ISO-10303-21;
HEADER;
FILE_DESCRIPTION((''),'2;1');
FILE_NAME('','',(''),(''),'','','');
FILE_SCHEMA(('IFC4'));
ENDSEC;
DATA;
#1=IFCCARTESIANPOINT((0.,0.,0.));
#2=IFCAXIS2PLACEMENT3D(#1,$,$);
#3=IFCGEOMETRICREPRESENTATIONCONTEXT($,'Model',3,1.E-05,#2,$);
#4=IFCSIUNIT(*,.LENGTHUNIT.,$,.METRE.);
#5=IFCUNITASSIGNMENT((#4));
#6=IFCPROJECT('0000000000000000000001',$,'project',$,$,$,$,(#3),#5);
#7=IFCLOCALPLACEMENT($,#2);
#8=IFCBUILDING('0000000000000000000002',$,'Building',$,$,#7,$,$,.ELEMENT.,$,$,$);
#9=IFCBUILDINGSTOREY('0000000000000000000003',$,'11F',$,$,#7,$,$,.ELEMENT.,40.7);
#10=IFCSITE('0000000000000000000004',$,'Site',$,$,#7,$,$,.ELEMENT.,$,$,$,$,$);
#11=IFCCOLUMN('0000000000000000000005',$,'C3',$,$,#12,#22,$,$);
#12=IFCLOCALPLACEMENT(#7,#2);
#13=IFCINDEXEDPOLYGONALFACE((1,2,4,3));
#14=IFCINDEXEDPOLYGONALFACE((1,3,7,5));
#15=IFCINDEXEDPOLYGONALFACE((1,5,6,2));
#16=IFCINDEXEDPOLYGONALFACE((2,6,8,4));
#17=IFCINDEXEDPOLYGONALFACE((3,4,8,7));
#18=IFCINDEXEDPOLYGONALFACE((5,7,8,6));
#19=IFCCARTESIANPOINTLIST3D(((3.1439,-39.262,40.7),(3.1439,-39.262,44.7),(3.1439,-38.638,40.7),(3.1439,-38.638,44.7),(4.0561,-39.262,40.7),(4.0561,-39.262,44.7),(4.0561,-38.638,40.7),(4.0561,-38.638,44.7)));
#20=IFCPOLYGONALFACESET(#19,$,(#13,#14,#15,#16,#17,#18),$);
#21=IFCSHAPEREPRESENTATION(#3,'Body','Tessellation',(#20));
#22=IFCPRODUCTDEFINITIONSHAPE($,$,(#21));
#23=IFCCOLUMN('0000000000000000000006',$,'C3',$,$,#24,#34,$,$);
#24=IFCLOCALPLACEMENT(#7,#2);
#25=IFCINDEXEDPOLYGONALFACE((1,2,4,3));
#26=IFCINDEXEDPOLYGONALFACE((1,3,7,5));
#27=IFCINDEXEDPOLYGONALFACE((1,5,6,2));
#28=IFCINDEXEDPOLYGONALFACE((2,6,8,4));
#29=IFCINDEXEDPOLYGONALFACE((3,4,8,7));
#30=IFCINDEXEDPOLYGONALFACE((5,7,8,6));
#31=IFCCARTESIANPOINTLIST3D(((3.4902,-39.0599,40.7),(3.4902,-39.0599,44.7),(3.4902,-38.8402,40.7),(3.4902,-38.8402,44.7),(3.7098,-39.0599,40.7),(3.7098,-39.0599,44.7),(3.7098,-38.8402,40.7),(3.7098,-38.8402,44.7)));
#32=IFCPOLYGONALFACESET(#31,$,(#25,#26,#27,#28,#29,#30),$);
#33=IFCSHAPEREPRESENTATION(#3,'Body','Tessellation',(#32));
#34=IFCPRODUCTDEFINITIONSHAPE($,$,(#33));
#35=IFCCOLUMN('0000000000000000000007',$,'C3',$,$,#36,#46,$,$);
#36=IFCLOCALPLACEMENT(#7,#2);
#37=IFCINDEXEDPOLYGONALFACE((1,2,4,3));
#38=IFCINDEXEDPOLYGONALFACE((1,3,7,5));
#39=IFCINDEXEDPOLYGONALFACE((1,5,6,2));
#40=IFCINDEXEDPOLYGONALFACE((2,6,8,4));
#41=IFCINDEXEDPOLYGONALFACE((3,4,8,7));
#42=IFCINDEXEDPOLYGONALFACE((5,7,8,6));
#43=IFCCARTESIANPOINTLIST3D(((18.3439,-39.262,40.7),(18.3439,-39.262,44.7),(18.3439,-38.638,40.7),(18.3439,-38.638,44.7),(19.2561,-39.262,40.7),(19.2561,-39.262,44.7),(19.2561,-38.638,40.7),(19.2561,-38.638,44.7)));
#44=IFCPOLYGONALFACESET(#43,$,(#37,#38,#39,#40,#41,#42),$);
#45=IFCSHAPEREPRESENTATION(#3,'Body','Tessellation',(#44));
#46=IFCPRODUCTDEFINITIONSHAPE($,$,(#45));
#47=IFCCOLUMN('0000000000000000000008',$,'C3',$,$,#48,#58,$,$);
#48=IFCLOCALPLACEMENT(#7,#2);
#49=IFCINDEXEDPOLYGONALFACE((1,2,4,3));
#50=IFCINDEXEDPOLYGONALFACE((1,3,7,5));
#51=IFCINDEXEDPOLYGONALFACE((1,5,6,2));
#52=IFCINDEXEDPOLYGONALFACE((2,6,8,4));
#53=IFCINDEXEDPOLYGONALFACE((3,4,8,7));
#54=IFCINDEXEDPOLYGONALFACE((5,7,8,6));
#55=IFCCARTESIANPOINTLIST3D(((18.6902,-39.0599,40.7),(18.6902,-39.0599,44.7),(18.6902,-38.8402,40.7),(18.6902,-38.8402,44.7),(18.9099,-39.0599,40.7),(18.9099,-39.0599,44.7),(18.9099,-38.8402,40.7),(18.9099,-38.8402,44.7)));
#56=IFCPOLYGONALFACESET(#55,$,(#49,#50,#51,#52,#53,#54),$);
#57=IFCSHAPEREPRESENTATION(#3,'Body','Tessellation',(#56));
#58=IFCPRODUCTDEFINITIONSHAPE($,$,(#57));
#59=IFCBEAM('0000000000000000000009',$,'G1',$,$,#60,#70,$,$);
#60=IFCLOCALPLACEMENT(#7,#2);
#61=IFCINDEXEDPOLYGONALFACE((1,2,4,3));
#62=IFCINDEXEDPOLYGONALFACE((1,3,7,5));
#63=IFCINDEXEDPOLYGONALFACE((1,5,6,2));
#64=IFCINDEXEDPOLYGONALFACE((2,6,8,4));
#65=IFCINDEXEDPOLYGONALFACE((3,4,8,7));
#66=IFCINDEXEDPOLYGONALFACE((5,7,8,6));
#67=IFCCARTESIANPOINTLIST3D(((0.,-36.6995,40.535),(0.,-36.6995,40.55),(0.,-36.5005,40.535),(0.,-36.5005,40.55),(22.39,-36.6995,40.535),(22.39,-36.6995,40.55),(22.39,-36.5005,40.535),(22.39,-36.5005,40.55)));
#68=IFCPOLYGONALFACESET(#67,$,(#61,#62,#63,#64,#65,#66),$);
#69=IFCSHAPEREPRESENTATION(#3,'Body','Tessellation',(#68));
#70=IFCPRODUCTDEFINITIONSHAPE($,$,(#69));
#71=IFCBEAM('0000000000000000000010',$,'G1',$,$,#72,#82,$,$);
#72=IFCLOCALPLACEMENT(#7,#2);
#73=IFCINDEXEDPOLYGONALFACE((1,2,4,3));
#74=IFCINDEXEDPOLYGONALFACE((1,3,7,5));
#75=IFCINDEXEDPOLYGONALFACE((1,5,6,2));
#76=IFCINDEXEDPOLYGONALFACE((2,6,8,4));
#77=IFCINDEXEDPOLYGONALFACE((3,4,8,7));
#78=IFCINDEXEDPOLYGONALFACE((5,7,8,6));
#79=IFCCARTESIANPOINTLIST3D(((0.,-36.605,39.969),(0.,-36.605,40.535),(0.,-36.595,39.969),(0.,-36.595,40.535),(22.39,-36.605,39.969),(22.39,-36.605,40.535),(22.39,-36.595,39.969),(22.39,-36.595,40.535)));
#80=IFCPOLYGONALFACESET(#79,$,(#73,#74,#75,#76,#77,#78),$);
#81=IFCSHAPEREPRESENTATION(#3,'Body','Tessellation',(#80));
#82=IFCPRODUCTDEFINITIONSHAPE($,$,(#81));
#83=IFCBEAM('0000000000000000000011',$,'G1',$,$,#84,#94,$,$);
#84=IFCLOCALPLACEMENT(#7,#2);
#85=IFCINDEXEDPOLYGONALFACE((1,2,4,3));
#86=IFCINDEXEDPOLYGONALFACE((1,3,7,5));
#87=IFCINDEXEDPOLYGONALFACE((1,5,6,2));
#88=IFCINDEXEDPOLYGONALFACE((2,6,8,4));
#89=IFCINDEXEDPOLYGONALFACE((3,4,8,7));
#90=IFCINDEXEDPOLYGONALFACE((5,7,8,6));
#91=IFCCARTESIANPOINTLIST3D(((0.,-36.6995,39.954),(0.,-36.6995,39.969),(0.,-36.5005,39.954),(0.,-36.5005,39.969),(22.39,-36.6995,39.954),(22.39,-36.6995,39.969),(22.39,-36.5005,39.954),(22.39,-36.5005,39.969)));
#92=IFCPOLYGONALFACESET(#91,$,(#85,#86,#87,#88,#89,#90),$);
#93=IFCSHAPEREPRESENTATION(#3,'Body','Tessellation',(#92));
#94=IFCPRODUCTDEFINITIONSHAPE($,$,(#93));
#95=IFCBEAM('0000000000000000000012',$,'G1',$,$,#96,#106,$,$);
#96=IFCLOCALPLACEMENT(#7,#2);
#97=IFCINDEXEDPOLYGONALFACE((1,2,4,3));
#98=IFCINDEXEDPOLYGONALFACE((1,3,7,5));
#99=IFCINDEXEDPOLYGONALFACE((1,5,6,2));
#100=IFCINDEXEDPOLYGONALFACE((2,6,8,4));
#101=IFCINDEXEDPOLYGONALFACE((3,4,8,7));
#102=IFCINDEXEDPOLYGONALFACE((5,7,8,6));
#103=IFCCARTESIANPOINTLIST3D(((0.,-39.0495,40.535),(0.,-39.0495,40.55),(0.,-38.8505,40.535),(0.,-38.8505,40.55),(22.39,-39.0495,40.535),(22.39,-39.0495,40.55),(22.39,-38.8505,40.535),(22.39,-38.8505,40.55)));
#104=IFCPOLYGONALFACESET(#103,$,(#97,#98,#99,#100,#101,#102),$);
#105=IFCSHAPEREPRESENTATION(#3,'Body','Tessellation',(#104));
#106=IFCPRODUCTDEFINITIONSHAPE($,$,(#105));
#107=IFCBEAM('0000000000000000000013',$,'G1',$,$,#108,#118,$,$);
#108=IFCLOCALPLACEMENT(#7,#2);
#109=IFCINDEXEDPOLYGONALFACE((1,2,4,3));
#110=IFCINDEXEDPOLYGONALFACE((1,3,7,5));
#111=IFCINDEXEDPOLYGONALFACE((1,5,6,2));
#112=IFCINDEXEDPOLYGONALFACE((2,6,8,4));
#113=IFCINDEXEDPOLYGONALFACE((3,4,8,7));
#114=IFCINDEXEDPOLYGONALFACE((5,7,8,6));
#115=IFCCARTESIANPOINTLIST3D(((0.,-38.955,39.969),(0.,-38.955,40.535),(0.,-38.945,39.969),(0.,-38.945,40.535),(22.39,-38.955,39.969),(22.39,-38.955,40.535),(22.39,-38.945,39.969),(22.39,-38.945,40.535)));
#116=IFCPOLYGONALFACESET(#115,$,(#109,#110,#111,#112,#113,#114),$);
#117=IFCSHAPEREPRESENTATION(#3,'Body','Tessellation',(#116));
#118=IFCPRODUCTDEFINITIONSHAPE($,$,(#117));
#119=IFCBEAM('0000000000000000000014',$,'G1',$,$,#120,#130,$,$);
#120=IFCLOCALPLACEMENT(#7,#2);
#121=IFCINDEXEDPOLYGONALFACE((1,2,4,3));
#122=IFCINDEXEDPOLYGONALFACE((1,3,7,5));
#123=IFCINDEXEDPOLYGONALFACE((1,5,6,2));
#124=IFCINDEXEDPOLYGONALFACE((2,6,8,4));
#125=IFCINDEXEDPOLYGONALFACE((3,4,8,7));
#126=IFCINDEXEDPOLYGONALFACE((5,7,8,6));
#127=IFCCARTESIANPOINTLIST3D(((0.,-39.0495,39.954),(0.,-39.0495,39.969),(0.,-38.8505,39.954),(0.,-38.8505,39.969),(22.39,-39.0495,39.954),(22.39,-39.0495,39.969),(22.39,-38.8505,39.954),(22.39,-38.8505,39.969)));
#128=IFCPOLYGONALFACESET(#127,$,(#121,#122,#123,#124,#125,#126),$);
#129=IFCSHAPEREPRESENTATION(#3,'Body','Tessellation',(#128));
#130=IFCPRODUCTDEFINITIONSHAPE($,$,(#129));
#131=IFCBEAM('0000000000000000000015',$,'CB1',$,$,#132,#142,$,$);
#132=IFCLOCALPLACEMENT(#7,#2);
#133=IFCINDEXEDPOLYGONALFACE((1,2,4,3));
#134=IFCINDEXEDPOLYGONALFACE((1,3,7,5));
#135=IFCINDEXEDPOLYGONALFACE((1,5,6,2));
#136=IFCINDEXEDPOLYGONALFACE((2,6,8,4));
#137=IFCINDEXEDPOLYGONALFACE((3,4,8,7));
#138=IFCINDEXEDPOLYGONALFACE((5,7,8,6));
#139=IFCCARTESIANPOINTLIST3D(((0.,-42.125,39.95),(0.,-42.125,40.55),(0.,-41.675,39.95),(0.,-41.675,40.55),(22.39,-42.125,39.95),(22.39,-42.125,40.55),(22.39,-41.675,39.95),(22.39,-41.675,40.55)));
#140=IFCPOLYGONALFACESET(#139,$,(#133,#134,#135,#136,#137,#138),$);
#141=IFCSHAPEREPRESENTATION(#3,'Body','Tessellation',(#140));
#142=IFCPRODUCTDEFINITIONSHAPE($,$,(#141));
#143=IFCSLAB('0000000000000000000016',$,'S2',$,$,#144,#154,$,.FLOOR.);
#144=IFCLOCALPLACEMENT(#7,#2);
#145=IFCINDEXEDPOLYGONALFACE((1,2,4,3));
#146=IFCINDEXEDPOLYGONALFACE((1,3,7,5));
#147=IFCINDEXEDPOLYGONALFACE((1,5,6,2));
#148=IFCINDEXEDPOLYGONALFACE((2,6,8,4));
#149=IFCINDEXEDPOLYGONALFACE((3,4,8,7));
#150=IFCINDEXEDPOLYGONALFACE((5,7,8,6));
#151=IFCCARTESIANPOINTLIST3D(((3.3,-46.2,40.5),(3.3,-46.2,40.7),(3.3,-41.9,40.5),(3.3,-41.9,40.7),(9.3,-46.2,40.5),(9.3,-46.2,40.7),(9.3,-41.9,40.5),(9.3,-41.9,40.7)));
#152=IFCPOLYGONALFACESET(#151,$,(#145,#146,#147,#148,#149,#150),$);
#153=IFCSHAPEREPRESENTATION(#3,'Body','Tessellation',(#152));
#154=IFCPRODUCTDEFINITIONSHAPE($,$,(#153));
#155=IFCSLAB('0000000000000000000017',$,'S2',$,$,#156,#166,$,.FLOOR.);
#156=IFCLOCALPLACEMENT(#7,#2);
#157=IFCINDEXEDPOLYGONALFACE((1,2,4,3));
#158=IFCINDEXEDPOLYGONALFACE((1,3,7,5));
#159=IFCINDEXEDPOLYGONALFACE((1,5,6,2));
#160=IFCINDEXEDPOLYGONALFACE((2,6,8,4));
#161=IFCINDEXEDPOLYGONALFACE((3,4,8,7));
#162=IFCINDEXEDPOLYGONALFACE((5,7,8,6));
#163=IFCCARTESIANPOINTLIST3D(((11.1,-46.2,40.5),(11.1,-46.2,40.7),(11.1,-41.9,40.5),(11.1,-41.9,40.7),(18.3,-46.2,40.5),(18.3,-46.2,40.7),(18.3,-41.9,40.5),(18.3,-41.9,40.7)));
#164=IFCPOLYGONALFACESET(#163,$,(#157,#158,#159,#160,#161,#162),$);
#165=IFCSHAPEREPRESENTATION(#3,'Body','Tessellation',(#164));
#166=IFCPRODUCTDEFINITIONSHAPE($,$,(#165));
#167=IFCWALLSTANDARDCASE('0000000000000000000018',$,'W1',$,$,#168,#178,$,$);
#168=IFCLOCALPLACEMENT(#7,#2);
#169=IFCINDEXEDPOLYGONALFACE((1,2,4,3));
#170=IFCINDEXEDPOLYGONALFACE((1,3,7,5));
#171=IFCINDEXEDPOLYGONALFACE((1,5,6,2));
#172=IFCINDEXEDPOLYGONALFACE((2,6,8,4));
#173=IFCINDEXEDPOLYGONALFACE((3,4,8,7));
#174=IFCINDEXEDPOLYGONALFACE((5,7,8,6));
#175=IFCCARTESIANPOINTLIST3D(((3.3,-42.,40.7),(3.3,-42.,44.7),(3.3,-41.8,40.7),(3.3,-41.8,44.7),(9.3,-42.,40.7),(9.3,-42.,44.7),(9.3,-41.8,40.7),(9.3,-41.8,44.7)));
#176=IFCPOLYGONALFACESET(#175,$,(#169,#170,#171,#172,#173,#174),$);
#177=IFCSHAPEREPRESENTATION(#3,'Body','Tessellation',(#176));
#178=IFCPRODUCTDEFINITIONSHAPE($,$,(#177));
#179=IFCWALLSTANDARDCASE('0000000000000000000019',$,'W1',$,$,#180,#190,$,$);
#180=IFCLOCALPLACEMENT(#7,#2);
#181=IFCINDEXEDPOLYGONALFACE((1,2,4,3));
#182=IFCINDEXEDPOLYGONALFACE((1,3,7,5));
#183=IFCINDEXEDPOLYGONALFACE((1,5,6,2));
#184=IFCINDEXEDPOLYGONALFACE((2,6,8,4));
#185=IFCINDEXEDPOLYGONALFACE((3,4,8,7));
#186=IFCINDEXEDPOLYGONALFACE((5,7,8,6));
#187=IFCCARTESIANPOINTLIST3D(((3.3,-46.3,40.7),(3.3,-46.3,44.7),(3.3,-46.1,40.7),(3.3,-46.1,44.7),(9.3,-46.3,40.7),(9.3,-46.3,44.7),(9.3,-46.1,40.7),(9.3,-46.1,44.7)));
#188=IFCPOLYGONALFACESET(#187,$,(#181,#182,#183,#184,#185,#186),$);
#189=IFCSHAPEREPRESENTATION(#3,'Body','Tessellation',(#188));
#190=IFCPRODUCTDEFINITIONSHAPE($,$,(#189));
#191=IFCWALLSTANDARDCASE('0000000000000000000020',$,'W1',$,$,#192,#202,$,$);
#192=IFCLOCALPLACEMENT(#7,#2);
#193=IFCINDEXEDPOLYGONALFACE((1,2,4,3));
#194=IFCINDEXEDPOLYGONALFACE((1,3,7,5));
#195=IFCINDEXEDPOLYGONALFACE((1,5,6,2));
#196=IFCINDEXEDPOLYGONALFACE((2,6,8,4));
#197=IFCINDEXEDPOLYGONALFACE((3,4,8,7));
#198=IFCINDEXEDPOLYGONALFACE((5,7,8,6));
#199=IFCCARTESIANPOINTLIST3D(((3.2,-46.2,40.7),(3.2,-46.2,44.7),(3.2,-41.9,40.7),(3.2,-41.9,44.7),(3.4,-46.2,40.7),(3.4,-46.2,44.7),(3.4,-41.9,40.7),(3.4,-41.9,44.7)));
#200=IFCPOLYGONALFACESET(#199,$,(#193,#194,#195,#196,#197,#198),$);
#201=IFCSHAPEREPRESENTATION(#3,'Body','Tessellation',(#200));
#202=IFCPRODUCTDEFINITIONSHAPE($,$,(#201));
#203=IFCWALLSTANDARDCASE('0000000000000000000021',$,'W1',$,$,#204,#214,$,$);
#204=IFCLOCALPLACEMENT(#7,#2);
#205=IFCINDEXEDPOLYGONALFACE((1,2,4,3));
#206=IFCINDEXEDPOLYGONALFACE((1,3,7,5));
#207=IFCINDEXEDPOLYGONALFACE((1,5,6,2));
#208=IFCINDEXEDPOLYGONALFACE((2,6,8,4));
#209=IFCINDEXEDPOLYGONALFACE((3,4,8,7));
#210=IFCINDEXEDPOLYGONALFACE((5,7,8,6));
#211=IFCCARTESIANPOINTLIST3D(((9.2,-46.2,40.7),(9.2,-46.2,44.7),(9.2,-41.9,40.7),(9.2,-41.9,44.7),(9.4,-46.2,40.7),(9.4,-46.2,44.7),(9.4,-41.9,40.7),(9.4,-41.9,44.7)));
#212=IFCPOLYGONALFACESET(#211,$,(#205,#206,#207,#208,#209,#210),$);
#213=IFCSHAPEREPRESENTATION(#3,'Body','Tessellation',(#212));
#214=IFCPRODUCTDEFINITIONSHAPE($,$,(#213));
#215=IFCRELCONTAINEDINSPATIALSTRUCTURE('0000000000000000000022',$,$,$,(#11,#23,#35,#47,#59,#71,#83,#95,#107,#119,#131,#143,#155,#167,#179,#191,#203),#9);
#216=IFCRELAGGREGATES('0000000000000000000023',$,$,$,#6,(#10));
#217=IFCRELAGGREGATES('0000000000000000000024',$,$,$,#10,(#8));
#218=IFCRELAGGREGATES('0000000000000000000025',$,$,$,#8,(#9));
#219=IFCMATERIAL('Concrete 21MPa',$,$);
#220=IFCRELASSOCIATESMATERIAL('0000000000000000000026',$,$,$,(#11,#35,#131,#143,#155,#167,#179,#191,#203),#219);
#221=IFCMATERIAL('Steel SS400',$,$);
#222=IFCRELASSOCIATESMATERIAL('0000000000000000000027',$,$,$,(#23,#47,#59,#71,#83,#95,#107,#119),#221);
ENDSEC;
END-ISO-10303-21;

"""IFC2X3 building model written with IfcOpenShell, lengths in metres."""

from ifc_helpers import new_model, si_unit, frame, origin, origin_2d, place, context, project, spatial, rectangle, extrude, material, element, save


model = new_model("IFC2X3")

# Units and contexts
model_context = context("Model", 3, precision=1e-05, world=origin())
ifc_project = project(units=[si_unit("LENGTHUNIT", "METRE")], contexts=[model_context])

# Site, building, storey
placement = place(None, origin())
site = spatial("IfcSite", under=ifc_project, at=placement, Name="Site", CompositionType="ELEMENT")
building = spatial("IfcBuilding", under=site, at=placement, Name="Building", CompositionType="ELEMENT")
storey = spatial("IfcBuildingStorey", under=building, at=placement, Name="11F", CompositionType="ELEMENT", Elevation=40.7)

# Columns
ifc_material_1 = material(Name="Concrete 21MPa")
column_1_placement = place(None, frame((3.6, -38.95, 40.7)))
element("IfcColumn", 1, at=column_1_placement, inside=storey, material=ifc_material_1, Name="C3", context=model_context, shape_type="SweptSolid", body=[
    extrude(rectangle(XDim=0.9121, YDim=0.6241, at=origin_2d()), origin(), (0.0, 0.0, 1.0), 4.0),
])
ifc_material_2 = material(Name="Steel SS400")
column_2_placement = place(None, frame((3.6, -38.95, 40.7)))
element("IfcColumn", 2, at=column_2_placement, inside=storey, material=ifc_material_2, Name="C3", context=model_context, shape_type="SweptSolid", body=[
    extrude(rectangle(XDim=0.2197, YDim=0.2197, at=origin_2d()), origin(), (0.0, 0.0, 1.0), 4.0),
])
column_3_placement = place(None, frame((18.8, -38.95, 40.7)))
element("IfcColumn", 3, at=column_3_placement, inside=storey, material=ifc_material_1, Name="C3", context=model_context, shape_type="SweptSolid", body=[
    extrude(rectangle(XDim=0.9121, YDim=0.6241, at=origin_2d()), origin(), (0.0, 0.0, 1.0), 4.0),
])
column_4_placement = place(None, frame((18.8, -38.95, 40.7)))
element("IfcColumn", 4, at=column_4_placement, inside=storey, material=ifc_material_2, Name="C3", context=model_context, shape_type="SweptSolid", body=[
    extrude(rectangle(XDim=0.2197, YDim=0.2197, at=origin_2d()), origin(), (0.0, 0.0, 1.0), 4.0),
])

# Beams
beam_1_placement = place(None, frame((11.195, -36.6, 40.535)))
element("IfcBeam", 5, at=beam_1_placement, inside=storey, material=ifc_material_2, Name="G1", context=model_context, shape_type="SweptSolid", body=[
    extrude(rectangle(XDim=22.39, YDim=0.199, at=origin_2d()), origin(), (0.0, 0.0, 1.0), 0.015),
])
beam_2_placement = place(None, frame((11.195, -36.6, 39.969)))
element("IfcBeam", 6, at=beam_2_placement, inside=storey, material=ifc_material_2, Name="G1", context=model_context, shape_type="SweptSolid", body=[
    extrude(rectangle(XDim=22.39, YDim=0.01, at=origin_2d()), origin(), (0.0, 0.0, 1.0), 0.566),
])
for number, where, name in (
    (7, (11.195, -36.6, 39.954), "G1"),
    (8, (11.195, -38.95, 40.535), "G1"),
):
    element("IfcBeam", number, at=place(None, frame(where)), inside=storey, material=ifc_material_2, Name=name, context=model_context, shape_type="SweptSolid", body=[
        extrude(rectangle(XDim=22.39, YDim=0.199, at=origin_2d()), origin(), (0.0, 0.0, 1.0), 0.015),
    ])
beam_3_placement = place(None, frame((11.195, -38.95, 39.969)))
element("IfcBeam", 9, at=beam_3_placement, inside=storey, material=ifc_material_2, Name="G1", context=model_context, shape_type="SweptSolid", body=[
    extrude(rectangle(XDim=22.39, YDim=0.01, at=origin_2d()), origin(), (0.0, 0.0, 1.0), 0.566),
])
beam_4_placement = place(None, frame((11.195, -38.95, 39.954)))
element("IfcBeam", 10, at=beam_4_placement, inside=storey, material=ifc_material_2, Name="G1", context=model_context, shape_type="SweptSolid", body=[
    extrude(rectangle(XDim=22.39, YDim=0.199, at=origin_2d()), origin(), (0.0, 0.0, 1.0), 0.015),
])
beam_5_placement = place(None, frame((11.195, -41.9, 39.95)))
element("IfcBeam", 11, at=beam_5_placement, inside=storey, material=ifc_material_1, Name="CB1", context=model_context, shape_type="SweptSolid", body=[
    extrude(rectangle(XDim=22.39, YDim=0.45, at=origin_2d()), origin(), (0.0, 0.0, 1.0), 0.6),
])

# Slabs
slab_1_placement = place(None, frame((6.3, -44.05, 40.5)))
element("IfcSlab", 12, at=slab_1_placement, inside=storey, material=ifc_material_1, Name="S2", PredefinedType="FLOOR", context=model_context, shape_type="SweptSolid", body=[
    extrude(rectangle(XDim=6.0, YDim=4.3, at=origin_2d()), origin(), (0.0, 0.0, 1.0), 0.2),
])
slab_2_placement = place(None, frame((14.7, -44.05, 40.5)))
element("IfcSlab", 13, at=slab_2_placement, inside=storey, material=ifc_material_1, Name="S2", PredefinedType="FLOOR", context=model_context, shape_type="SweptSolid", body=[
    extrude(rectangle(XDim=7.2, YDim=4.3, at=origin_2d()), origin(), (0.0, 0.0, 1.0), 0.2),
])

# Walls
for number, where, name in (
    (14, (6.3, -41.9, 40.7), "W1"),
    (15, (6.3, -46.2, 40.7), "W1"),
):
    element("IfcWallStandardCase", number, at=place(None, frame(where)), inside=storey, material=ifc_material_1, Name=name, context=model_context, shape_type="SweptSolid", body=[
        extrude(rectangle(XDim=6.0, YDim=0.2, at=origin_2d()), origin(), (0.0, 0.0, 1.0), 4.0),
    ])
for number, where, name in (
    (16, (3.3, -44.05, 40.7), "W1"),
    (17, (9.3, -44.05, 40.7), "W1"),
):
    element("IfcWallStandardCase", number, at=place(None, frame(where)), inside=storey, material=ifc_material_1, Name=name, context=model_context, shape_type="SweptSolid", body=[
        extrude(rectangle(XDim=0.2, YDim=4.3, at=origin_2d()), origin(), (0.0, 0.0, 1.0), 4.0),
    ])

save(model, "model.ifc")
